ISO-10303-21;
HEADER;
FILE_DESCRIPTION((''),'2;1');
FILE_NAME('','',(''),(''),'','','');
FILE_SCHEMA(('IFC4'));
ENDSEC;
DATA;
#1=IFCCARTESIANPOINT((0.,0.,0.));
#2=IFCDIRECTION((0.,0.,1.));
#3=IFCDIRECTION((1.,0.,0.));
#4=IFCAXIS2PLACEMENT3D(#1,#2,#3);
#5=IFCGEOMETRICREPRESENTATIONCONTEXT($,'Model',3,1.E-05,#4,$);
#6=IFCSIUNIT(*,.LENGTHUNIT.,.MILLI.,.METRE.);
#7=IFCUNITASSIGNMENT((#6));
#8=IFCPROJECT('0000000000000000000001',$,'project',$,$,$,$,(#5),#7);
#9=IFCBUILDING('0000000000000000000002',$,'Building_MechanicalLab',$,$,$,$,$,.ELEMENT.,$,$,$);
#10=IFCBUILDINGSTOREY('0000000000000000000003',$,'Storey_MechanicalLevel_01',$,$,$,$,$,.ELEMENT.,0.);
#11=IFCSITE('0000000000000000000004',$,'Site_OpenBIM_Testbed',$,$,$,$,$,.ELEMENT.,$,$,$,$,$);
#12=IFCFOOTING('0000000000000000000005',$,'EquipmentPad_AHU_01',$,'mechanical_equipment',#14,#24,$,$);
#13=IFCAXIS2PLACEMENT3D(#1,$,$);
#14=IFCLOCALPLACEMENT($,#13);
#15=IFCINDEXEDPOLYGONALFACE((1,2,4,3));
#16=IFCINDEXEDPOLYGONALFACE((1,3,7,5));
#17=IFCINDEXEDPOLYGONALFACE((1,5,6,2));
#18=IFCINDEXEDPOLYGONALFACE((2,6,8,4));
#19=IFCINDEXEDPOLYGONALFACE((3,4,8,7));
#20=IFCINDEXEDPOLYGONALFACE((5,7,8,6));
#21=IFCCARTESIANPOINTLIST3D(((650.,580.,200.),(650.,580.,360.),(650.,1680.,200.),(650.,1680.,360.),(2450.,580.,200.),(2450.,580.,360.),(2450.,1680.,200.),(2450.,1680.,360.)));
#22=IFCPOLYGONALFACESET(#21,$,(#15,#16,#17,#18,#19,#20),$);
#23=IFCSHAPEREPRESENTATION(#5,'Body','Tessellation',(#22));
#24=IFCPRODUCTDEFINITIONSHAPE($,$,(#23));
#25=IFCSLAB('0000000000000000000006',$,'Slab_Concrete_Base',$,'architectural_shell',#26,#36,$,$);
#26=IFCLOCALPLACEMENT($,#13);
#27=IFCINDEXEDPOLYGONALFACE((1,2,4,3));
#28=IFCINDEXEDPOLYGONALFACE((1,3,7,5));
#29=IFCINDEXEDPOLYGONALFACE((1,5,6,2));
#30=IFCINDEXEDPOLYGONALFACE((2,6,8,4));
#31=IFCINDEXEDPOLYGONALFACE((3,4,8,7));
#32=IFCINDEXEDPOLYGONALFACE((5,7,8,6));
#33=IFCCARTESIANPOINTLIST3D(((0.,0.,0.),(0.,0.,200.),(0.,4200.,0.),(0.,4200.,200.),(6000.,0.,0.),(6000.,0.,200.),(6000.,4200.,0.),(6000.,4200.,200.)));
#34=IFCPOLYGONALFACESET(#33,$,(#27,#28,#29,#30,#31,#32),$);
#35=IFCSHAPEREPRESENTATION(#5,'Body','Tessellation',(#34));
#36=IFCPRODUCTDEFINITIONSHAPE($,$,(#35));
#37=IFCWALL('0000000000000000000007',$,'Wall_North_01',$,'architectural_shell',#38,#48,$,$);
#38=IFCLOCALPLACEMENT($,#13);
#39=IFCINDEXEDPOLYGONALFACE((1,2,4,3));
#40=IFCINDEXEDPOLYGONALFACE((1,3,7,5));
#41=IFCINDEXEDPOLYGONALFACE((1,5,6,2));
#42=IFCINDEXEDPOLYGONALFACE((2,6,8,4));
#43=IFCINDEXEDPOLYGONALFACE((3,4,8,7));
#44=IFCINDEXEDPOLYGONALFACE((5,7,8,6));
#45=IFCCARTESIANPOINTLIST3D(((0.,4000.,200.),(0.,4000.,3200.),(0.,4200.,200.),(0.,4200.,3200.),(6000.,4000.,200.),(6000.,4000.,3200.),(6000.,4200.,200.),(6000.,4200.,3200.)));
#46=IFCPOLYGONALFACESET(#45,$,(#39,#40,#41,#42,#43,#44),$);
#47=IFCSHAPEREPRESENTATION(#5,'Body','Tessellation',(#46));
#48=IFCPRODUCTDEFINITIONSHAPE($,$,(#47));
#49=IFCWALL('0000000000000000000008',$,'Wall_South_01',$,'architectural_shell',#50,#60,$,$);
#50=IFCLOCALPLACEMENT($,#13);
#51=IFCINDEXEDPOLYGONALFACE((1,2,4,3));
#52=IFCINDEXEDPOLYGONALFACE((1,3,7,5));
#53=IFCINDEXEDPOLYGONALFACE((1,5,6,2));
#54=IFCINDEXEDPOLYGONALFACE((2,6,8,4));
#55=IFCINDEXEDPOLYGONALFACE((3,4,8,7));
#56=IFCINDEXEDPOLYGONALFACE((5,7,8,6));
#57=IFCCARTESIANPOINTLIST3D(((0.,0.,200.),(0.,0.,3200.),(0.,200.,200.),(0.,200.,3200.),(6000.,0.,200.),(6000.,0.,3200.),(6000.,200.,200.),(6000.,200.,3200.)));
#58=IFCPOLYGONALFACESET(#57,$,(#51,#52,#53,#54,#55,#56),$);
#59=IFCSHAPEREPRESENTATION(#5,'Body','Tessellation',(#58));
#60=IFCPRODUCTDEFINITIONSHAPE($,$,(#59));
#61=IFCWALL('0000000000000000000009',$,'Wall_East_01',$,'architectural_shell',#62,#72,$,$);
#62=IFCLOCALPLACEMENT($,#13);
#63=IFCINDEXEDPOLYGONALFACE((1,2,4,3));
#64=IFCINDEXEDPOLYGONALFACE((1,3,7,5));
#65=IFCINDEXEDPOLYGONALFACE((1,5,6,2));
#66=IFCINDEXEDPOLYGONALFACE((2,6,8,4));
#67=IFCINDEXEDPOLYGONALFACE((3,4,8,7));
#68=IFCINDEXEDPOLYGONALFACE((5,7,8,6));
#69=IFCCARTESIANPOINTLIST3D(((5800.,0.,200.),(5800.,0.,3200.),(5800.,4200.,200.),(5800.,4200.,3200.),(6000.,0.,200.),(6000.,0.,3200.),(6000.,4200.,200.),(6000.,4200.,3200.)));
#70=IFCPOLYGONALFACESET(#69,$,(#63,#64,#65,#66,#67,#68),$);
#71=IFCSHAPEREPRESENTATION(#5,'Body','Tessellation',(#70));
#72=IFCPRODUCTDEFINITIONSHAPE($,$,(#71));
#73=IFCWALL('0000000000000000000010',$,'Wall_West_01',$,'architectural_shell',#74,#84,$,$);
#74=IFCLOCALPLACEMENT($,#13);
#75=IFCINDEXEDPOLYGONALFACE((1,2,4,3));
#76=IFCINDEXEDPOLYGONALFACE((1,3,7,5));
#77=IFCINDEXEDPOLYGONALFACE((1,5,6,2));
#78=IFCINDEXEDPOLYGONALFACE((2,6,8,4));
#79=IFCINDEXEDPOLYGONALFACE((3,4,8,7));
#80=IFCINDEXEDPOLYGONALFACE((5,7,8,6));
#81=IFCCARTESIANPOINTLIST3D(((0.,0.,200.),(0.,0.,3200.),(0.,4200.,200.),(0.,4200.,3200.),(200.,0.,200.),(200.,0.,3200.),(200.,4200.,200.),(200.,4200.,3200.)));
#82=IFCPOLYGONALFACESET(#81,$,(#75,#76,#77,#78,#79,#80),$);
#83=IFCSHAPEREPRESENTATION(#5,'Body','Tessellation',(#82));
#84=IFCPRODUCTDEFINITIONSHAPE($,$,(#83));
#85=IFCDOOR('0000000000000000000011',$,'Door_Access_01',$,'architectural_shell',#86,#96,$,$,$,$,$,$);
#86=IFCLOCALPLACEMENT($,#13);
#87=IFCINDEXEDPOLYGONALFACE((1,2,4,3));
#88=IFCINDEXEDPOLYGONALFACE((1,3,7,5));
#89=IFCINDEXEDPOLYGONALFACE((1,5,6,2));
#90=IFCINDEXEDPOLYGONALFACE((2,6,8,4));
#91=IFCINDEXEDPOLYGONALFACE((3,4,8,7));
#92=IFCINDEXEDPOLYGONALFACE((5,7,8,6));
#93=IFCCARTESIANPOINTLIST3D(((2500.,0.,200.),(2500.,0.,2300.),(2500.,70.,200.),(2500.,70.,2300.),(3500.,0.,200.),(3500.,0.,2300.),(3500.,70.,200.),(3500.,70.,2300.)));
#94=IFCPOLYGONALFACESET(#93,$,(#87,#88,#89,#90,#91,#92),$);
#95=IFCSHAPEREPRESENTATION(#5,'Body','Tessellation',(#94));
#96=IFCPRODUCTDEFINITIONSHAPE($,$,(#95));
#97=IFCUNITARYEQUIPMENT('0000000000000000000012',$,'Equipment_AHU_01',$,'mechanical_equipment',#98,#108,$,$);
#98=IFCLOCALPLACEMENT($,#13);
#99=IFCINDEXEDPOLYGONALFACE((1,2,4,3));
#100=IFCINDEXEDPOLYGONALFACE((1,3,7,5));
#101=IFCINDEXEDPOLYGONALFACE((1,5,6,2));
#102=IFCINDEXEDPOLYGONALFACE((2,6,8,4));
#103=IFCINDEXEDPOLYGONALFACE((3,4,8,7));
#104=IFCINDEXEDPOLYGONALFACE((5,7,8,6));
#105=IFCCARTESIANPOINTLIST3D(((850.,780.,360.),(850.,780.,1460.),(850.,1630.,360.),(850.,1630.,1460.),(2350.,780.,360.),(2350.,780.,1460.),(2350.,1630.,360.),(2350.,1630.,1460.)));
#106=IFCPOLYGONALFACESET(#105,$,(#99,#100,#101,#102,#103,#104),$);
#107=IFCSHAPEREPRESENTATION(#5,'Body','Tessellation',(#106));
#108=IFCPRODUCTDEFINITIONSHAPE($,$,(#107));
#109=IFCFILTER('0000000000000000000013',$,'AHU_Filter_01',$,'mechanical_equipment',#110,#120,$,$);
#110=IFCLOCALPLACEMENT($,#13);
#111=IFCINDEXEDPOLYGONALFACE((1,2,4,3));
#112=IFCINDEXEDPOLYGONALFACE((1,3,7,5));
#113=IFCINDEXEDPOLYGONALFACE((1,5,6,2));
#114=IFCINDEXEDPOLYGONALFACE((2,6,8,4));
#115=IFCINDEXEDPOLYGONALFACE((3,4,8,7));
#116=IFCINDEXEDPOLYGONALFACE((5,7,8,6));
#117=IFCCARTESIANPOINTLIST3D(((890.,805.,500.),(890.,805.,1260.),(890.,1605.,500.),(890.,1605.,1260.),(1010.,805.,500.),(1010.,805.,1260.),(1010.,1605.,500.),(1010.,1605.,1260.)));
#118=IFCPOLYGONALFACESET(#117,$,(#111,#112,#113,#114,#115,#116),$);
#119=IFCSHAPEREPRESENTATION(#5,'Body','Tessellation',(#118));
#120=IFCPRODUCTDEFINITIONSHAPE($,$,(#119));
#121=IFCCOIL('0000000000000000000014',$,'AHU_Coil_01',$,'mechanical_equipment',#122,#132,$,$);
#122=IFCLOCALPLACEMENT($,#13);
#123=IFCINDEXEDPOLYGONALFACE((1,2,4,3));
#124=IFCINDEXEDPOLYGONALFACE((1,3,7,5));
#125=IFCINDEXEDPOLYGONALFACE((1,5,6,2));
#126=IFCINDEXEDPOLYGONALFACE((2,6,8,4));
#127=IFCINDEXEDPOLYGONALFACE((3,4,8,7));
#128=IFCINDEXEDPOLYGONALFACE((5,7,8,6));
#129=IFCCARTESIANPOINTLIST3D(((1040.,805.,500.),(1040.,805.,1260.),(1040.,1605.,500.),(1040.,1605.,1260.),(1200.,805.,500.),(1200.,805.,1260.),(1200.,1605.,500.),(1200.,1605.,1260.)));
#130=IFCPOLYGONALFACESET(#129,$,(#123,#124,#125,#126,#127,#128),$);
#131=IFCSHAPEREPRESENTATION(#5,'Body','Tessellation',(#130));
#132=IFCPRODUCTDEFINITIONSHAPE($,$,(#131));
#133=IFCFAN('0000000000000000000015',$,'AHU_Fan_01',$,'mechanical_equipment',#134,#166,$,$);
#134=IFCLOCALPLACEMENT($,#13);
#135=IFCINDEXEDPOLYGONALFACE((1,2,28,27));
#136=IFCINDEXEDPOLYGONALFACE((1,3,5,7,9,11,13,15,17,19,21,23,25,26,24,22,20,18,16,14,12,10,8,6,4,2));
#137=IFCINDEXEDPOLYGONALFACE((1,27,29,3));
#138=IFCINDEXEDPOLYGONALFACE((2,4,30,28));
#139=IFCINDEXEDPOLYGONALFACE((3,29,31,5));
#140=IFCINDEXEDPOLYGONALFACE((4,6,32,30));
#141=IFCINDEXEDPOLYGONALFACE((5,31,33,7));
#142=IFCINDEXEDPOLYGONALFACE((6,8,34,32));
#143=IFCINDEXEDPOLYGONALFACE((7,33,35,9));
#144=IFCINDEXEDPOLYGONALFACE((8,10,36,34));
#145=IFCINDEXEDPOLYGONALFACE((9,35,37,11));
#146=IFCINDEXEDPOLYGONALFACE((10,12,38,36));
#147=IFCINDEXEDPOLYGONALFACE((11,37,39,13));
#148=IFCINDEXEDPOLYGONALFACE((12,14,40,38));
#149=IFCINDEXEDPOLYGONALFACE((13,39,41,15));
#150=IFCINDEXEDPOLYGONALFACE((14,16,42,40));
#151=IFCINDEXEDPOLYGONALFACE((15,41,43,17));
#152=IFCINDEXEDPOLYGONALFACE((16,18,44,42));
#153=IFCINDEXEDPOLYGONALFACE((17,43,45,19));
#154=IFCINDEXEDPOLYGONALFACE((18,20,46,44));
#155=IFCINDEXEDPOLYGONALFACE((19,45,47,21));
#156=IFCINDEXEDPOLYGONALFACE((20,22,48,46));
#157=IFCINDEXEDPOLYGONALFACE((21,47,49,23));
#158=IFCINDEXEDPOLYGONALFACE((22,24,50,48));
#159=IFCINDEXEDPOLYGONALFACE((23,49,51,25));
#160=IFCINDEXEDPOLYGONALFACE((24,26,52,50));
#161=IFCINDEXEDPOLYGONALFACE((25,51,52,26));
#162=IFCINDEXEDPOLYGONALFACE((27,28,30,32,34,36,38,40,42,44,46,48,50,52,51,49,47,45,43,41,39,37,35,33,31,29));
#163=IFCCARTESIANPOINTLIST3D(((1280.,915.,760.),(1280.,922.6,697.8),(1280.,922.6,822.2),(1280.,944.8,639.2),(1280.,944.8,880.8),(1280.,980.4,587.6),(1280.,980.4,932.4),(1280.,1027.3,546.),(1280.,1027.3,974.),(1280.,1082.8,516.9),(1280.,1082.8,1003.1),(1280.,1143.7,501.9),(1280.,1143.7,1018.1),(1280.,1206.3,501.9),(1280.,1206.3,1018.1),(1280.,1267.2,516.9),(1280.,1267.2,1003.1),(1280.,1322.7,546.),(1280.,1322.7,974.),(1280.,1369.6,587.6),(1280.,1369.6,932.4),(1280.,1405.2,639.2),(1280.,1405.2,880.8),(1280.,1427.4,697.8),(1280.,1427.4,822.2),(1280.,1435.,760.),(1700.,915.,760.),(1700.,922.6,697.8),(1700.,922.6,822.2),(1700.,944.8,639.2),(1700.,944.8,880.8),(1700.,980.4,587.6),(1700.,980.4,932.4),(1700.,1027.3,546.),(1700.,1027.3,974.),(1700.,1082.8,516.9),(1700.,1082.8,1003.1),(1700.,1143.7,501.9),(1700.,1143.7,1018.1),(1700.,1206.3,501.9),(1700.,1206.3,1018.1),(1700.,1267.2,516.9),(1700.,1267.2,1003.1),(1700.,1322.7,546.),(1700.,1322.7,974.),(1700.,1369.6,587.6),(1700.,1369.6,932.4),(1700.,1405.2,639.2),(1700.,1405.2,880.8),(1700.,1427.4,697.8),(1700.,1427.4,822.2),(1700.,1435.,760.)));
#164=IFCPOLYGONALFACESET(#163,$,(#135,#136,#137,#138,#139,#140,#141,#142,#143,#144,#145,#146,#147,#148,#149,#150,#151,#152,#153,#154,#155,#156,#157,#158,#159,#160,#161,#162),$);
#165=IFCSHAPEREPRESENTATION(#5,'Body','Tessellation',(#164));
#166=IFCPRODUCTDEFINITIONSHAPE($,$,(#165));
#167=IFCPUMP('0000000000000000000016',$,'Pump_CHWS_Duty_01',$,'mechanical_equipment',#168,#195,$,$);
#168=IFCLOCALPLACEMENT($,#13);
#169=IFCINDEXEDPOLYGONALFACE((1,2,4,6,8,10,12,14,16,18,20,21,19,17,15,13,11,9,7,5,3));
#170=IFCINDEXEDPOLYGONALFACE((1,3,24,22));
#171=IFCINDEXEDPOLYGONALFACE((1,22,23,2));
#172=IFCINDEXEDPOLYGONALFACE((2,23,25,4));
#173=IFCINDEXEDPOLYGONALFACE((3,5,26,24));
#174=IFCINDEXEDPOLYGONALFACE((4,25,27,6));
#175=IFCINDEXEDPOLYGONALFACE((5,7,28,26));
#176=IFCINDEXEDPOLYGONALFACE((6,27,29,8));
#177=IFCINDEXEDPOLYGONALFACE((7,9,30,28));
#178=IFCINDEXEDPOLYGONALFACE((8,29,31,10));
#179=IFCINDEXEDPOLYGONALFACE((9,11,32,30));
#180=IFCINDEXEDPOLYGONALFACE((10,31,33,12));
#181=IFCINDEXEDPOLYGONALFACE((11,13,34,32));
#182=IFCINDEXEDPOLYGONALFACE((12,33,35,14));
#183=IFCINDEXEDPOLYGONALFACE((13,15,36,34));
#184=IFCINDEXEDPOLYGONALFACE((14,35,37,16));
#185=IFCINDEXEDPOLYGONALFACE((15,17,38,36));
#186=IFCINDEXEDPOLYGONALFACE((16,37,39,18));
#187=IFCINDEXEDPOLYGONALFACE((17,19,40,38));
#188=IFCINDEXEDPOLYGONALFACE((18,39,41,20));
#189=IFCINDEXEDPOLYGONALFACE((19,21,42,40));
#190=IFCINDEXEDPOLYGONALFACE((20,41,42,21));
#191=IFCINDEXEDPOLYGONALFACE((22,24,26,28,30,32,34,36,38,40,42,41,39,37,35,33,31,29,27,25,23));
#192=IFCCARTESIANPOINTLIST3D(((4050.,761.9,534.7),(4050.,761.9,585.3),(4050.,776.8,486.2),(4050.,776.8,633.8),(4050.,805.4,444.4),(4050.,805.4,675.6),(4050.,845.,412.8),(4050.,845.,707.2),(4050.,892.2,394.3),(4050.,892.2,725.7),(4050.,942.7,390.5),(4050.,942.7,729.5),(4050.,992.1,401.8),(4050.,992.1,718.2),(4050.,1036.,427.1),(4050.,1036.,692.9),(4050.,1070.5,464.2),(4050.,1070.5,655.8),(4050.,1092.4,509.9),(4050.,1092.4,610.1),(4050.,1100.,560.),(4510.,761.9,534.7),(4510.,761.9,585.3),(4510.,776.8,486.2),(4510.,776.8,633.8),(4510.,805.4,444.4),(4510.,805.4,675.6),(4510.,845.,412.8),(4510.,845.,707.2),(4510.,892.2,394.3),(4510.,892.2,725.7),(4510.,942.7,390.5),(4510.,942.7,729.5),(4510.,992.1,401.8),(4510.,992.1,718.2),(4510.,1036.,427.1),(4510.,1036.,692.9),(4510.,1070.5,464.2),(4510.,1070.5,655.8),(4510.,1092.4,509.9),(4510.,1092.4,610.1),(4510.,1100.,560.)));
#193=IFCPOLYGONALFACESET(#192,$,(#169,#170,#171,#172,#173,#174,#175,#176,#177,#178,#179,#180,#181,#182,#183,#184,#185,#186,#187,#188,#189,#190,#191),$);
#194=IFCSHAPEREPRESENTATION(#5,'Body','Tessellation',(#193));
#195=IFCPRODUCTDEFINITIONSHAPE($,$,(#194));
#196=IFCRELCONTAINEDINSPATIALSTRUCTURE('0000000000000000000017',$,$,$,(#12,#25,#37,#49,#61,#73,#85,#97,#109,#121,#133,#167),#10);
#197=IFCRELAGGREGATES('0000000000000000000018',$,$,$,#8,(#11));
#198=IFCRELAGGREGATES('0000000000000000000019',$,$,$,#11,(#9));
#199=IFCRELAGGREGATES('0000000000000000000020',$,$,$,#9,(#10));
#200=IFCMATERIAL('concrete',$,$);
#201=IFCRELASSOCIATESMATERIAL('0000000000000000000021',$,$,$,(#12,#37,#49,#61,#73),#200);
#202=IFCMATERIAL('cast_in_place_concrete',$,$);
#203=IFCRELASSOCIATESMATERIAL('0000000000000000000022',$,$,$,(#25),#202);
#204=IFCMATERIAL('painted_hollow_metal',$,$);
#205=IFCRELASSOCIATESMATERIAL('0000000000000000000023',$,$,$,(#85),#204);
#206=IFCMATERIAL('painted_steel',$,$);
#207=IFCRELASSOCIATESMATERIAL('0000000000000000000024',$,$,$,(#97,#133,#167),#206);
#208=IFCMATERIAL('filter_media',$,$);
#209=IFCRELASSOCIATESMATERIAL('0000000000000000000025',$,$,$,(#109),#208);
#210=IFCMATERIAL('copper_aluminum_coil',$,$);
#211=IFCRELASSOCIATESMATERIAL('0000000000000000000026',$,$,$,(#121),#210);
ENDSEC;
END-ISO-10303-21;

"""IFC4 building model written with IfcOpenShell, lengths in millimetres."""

from ifc_helpers import new_model, si_unit, frame, origin_with_axes, place, context, project, spatial, rectangle, circle, extrude, material, element, save


model = new_model("IFC4")

# Units and contexts
model_context = context("Model", 3, precision=1e-05, world=origin_with_axes())
ifc_project = project(units=[si_unit("LENGTHUNIT", "METRE", prefix="MILLI")], contexts=[model_context])

# Site, building, storey
site = spatial("IfcSite", under=ifc_project, Name="Site_OpenBIM_Testbed", CompositionType="ELEMENT")
building = spatial("IfcBuilding", under=site, Name="Building_MechanicalLab", CompositionType="ELEMENT")
storey = spatial("IfcBuildingStorey", under=building, Name="Storey_MechanicalLevel_01", CompositionType="ELEMENT", Elevation=0.0)

# Footing
ifc_material_1 = material(Name="concrete")
footing_placement = place(None, frame((650.0, 580.0, 200.0), z_axis=(0.0, 0.0, 1.0), x_axis=(1.0, 0.0, 0.0)))
element("IfcFooting", 1, at=footing_placement, inside=storey, material=ifc_material_1, Name="EquipmentPad_AHU_01", ObjectType="mechanical_equipment", context=model_context, shape_type="SweptSolid", body=[
    extrude(rectangle(XDim=1800.0, YDim=1100.0), frame((900.0, 550.0, 0.0), z_axis=(0.0, 0.0, 1.0), x_axis=(1.0, 0.0, 0.0)), (0.0, 0.0, 1.0), 160.0),
])

# Slab
ifc_material_2 = material(Name="cast_in_place_concrete")
slab_placement = place(None, origin_with_axes())
element("IfcSlab", 2, at=slab_placement, inside=storey, material=ifc_material_2, Name="Slab_Concrete_Base", ObjectType="architectural_shell", context=model_context, shape_type="SweptSolid", body=[
    extrude(rectangle(XDim=6000.0, YDim=4200.0), frame((3000.0, 2100.0, 0.0), z_axis=(0.0, 0.0, 1.0), x_axis=(1.0, 0.0, 0.0)), (0.0, 0.0, 1.0), 200.0),
])

# Walls
for number, where, z_axis, x_axis, name in (
    (3, (0.0, 4000.0, 200.0), (0.0, 0.0, 1.0), (1.0, 0.0, 0.0), "Wall_North_01"),
    (4, (0.0, 0.0, 200.0), (0.0, 0.0, 1.0), (1.0, 0.0, 0.0), "Wall_South_01"),
):
    element("IfcWall", number, at=place(None, frame(where, z_axis=z_axis, x_axis=x_axis)), inside=storey, material=ifc_material_1, Name=name, ObjectType="architectural_shell", context=model_context, shape_type="SweptSolid", body=[
        extrude(rectangle(XDim=6000.0, YDim=200.0), frame((3000.0, 100.0, 0.0), z_axis=(0.0, 0.0, 1.0), x_axis=(1.0, 0.0, 0.0)), (0.0, 0.0, 1.0), 3000.0),
    ])
for number, where, z_axis, x_axis, name in (
    (5, (5800.0, 0.0, 200.0), (0.0, 0.0, 1.0), (1.0, 0.0, 0.0), "Wall_East_01"),
    (6, (0.0, 0.0, 200.0), (0.0, 0.0, 1.0), (1.0, 0.0, 0.0), "Wall_West_01"),
):
    element("IfcWall", number, at=place(None, frame(where, z_axis=z_axis, x_axis=x_axis)), inside=storey, material=ifc_material_1, Name=name, ObjectType="architectural_shell", context=model_context, shape_type="SweptSolid", body=[
        extrude(rectangle(XDim=200.0, YDim=4200.0), frame((100.0, 2100.0, 0.0), z_axis=(0.0, 0.0, 1.0), x_axis=(1.0, 0.0, 0.0)), (0.0, 0.0, 1.0), 3000.0),
    ])

# Door
ifc_material_3 = material(Name="painted_hollow_metal")
door_placement = place(None, frame((2500.0, 0.0, 200.0), z_axis=(0.0, 0.0, 1.0), x_axis=(1.0, 0.0, 0.0)))
element("IfcDoor", 7, at=door_placement, inside=storey, material=ifc_material_3, Name="Door_Access_01", ObjectType="architectural_shell", context=model_context, shape_type="SweptSolid", body=[
    extrude(rectangle(XDim=1000.0, YDim=70.0), frame((500.0, 35.0, 0.0), z_axis=(0.0, 0.0, 1.0), x_axis=(1.0, 0.0, 0.0)), (0.0, 0.0, 1.0), 2100.0),
])

# Unitary equipment
ifc_material_4 = material(Name="painted_steel")
unitary_equipment_placement = place(None, frame((850.0, 780.0, 360.0), z_axis=(0.0, 0.0, 1.0), x_axis=(1.0, 0.0, 0.0)))
element("IfcUnitaryEquipment", 8, at=unitary_equipment_placement, inside=storey, material=ifc_material_4, Name="Equipment_AHU_01", ObjectType="mechanical_equipment", context=model_context, shape_type="SweptSolid", body=[
    extrude(rectangle(XDim=1500.0, YDim=850.0), frame((750.0, 425.0, 0.0), z_axis=(0.0, 0.0, 1.0), x_axis=(1.0, 0.0, 0.0)), (0.0, 0.0, 1.0), 1100.0),
])

# Filter
ifc_material_5 = material(Name="filter_media")
ifc_filter_placement = place(None, frame((890.0, 805.0, 500.0), z_axis=(0.0, 0.0, 1.0), x_axis=(1.0, 0.0, 0.0)))
element("IfcFilter", 9, at=ifc_filter_placement, inside=storey, material=ifc_material_5, Name="AHU_Filter_01", ObjectType="mechanical_equipment", context=model_context, shape_type="SweptSolid", body=[
    extrude(rectangle(XDim=120.0, YDim=800.0), frame((60.0, 400.0, 0.0), z_axis=(0.0, 0.0, 1.0), x_axis=(1.0, 0.0, 0.0)), (0.0, 0.0, 1.0), 760.0),
])

# Coil
ifc_material_6 = material(Name="copper_aluminum_coil")
coil_placement = place(None, frame((1040.0, 805.0, 500.0), z_axis=(0.0, 0.0, 1.0), x_axis=(1.0, 0.0, 0.0)))
element("IfcCoil", 10, at=coil_placement, inside=storey, material=ifc_material_6, Name="AHU_Coil_01", ObjectType="mechanical_equipment", context=model_context, shape_type="SweptSolid", body=[
    extrude(rectangle(XDim=160.0, YDim=800.0), frame((80.0, 400.0, 0.0), z_axis=(0.0, 0.0, 1.0), x_axis=(1.0, 0.0, 0.0)), (0.0, 0.0, 1.0), 760.0),
])

# Fan
fan_placement = place(None, frame((1280.0, 1175.0, 760.0), z_axis=(0.0, 0.0, 1.0), x_axis=(1.0, 0.0, 0.0)))
element("IfcFan", 11, at=fan_placement, inside=storey, material=ifc_material_4, Name="AHU_Fan_01", ObjectType="mechanical_equipment", context=model_context, shape_type="SweptSolid", body=[
    extrude(circle(Radius=260.0), frame((0.0, 0.0, 0.0), z_axis=(1.0, 0.0, 0.0), x_axis=(0.0, 1.0, 0.0)), (0.0, 0.0, 1.0), 420.0),
])

# Pump
for number, where, z_axis, x_axis, name in (
    (12, (4050.0, 930.0, 560.0), (0.0, 0.0, 1.0), (1.0, 0.0, 0.0), "Pump_CHWS_Duty_01"),
):
    element("IfcPump", number, at=place(None, frame(where, z_axis=z_axis, x_axis=x_axis)), inside=storey, material=ifc_material_4, Name=name, ObjectType="mechanical_equipment", context=model_context, shape_type="SweptSolid", body=[
        extrude(circle(Radius=170.0), frame((0.0, 0.0, 0.0), z_axis=(1.0, 0.0, 0.0), x_axis=(0.0, 1.0, 0.0)), (0.0, 0.0, 1.0), 460.0),
    ])

save(model, "model.ifc")
